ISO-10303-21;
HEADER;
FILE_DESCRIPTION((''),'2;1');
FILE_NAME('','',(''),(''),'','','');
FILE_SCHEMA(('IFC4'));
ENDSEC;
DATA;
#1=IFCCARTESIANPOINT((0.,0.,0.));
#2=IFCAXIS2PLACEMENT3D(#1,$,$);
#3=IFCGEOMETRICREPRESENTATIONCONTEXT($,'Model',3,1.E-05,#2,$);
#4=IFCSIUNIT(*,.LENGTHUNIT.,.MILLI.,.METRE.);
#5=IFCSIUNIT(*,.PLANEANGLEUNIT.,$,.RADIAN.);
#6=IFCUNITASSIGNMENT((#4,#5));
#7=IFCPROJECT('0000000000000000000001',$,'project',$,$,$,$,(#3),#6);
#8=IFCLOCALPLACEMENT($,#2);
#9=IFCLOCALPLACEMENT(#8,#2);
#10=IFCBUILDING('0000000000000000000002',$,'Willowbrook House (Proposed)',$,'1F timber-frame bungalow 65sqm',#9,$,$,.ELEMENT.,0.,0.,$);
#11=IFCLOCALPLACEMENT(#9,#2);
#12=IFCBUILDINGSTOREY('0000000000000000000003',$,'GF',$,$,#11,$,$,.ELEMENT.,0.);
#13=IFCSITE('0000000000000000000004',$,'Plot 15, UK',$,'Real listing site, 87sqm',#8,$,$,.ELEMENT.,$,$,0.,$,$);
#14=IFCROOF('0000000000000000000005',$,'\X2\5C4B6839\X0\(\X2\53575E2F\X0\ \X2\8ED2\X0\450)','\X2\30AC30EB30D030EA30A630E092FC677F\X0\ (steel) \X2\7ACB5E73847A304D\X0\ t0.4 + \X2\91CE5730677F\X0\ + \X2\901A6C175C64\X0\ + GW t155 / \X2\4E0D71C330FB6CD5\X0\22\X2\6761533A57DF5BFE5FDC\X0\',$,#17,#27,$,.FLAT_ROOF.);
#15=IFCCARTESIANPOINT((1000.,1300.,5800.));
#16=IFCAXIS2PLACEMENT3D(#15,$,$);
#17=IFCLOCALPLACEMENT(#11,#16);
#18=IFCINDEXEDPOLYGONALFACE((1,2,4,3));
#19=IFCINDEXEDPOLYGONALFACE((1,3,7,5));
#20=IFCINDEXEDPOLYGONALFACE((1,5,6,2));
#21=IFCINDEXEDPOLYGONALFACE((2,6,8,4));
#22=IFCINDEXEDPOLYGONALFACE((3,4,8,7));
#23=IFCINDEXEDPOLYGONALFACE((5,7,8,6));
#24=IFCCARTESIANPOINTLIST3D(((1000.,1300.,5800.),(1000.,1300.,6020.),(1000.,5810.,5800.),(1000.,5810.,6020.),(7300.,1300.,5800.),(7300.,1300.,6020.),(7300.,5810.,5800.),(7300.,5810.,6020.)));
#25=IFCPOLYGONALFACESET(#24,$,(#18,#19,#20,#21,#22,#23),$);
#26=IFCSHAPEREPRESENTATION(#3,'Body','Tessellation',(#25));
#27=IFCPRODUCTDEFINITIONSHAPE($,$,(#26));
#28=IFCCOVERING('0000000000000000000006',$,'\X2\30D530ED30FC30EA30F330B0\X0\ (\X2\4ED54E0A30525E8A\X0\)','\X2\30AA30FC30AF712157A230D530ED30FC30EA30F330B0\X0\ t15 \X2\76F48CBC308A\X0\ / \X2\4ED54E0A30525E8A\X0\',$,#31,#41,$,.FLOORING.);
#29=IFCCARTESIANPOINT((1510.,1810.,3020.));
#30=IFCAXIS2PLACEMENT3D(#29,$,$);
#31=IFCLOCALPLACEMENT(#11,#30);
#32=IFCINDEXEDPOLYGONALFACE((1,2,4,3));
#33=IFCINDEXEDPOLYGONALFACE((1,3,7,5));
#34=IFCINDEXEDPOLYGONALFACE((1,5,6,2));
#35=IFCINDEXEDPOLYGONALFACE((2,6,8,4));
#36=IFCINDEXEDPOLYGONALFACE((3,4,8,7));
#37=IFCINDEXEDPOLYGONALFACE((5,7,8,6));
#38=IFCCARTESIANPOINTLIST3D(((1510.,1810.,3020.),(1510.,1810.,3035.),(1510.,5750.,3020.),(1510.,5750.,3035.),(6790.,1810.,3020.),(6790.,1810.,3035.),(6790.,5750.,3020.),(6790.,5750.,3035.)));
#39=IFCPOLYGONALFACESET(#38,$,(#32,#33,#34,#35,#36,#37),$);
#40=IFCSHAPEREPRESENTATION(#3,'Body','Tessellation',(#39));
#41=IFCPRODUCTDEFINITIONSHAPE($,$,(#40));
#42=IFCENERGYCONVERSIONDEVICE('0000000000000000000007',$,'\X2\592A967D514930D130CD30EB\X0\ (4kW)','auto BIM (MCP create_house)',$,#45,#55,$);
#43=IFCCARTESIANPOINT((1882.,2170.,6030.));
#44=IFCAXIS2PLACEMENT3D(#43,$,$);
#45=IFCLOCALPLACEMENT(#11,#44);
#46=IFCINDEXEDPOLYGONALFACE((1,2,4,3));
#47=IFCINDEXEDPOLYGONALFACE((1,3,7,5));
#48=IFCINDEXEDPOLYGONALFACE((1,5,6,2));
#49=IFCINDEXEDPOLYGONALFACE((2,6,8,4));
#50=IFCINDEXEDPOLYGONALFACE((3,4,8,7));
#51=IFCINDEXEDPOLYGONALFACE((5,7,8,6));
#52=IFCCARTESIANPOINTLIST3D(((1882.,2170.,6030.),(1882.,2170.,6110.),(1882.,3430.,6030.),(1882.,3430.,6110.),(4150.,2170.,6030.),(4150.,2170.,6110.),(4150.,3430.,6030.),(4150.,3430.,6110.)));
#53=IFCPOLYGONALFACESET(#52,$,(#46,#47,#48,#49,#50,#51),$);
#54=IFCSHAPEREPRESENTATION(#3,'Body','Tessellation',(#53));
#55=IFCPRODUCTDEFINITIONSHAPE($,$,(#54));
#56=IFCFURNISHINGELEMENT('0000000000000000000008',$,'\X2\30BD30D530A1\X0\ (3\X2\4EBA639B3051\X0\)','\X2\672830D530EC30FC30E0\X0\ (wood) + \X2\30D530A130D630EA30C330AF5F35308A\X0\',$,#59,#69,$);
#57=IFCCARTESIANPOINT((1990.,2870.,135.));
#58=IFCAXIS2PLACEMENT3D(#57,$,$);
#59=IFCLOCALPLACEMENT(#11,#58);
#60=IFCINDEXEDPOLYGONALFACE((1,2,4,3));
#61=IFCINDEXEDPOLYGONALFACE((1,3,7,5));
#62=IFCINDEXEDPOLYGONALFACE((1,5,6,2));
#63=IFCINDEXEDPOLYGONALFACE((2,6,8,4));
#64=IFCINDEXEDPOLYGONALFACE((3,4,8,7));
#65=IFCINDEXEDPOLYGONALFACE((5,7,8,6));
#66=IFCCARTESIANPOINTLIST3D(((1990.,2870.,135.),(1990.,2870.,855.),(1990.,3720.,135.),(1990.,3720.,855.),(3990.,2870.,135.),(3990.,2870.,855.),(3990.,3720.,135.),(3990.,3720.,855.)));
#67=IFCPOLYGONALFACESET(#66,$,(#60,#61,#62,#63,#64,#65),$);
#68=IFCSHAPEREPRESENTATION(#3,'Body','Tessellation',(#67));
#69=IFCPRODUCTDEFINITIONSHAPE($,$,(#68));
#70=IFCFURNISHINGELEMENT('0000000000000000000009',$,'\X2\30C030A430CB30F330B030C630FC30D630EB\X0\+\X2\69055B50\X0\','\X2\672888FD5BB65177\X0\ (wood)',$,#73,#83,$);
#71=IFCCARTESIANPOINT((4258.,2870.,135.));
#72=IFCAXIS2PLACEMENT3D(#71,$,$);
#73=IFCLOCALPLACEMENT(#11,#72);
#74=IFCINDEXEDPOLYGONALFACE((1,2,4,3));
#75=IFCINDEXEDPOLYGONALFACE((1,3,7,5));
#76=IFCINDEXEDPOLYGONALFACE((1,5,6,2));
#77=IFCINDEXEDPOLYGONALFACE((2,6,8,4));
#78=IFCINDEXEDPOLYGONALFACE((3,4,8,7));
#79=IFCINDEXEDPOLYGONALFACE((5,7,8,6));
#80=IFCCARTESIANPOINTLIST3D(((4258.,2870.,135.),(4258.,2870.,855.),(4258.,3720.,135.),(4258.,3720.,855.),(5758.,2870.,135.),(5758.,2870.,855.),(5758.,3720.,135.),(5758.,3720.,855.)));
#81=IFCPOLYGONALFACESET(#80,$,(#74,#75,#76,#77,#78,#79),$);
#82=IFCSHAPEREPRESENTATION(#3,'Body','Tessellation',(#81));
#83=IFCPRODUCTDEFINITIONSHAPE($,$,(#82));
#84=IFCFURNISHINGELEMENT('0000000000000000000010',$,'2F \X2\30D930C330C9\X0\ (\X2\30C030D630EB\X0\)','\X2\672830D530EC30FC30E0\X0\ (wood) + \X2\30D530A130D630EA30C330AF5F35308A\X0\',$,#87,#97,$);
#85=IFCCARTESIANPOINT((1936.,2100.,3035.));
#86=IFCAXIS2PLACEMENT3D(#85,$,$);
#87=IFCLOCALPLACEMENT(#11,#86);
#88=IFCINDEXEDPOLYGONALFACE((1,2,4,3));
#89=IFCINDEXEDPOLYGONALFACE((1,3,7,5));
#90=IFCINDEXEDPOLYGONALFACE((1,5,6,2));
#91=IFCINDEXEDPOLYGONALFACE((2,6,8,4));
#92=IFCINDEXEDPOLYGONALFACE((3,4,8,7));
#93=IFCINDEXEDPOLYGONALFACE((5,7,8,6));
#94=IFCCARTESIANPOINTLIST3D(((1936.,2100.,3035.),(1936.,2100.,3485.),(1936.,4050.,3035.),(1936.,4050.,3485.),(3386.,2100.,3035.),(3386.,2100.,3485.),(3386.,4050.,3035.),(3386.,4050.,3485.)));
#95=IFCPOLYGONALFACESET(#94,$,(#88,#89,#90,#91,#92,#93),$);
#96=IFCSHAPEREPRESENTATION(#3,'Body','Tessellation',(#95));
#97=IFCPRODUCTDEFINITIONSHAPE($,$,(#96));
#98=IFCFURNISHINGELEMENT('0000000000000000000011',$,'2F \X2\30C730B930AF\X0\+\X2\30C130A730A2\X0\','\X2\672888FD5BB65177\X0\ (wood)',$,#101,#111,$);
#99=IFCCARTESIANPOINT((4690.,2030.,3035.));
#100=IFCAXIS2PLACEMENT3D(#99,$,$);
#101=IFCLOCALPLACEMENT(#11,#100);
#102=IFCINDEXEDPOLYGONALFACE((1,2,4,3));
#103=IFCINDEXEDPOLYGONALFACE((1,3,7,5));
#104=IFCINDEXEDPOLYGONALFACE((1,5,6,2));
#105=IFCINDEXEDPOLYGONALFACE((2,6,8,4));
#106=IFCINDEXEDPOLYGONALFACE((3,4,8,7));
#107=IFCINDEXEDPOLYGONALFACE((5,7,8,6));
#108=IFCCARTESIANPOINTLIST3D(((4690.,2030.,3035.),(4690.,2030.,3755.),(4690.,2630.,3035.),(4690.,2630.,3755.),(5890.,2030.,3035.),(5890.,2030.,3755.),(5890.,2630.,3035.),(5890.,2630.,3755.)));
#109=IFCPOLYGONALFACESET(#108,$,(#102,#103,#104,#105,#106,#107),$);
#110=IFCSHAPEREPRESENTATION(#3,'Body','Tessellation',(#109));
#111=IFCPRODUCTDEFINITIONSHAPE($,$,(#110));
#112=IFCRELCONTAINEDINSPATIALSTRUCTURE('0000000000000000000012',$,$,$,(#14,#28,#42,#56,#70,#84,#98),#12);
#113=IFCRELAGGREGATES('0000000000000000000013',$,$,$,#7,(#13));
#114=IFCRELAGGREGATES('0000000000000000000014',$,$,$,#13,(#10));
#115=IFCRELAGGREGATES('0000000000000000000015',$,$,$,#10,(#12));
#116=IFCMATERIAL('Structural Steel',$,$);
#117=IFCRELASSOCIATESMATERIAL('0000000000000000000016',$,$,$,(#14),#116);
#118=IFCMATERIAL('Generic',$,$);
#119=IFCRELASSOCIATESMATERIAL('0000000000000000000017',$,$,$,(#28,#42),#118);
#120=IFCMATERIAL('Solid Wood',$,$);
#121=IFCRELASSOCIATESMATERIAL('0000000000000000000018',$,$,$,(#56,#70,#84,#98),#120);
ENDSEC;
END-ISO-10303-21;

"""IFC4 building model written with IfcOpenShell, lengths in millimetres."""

from ifc_helpers import new_model, si_unit, frame, frame_2d, origin, place, context, project, spatial, rectangle, extrude, material, element, save


model = new_model("IFC4")

# Units and contexts
model_context = context("Model", 3, precision=1e-05, world=origin())
ifc_project = project(units=[si_unit("LENGTHUNIT", "METRE", prefix="MILLI"), si_unit("PLANEANGLEUNIT", "RADIAN")], contexts=[model_context])

# Site, building, storey
site_placement = place(None, origin())
site = spatial("IfcSite", under=ifc_project, at=site_placement, Name="Plot 15, UK", ObjectType="Real listing site, 87sqm", CompositionType="ELEMENT", RefElevation=0.0)
building_placement = place(site_placement, origin())
building = spatial("IfcBuilding", under=site, at=building_placement, Name="Willowbrook House (Proposed)", ObjectType="1F timber-frame bungalow 65sqm", CompositionType="ELEMENT", ElevationOfRefHeight=0.0, ElevationOfTerrain=0.0)
storey_placement = place(building_placement, origin())
storey = spatial("IfcBuildingStorey", under=building, at=storey_placement, Name="GF", CompositionType="ELEMENT", Elevation=0.0)

# Shared definitions
ifc_material_1 = material(Name="Solid Wood")

# Shared definitions
ifc_material_2 = material(Name="Generic")

# Roof
ifc_material_3 = material(Name="Structural Steel")
for number, where, name in (
    (1, (1000.0, 1300.0, 5800.0), "屋根(南帯 軒450)"),
):
    element("IfcRoof", number, at=place(storey_placement, frame(where)), inside=storey, material=ifc_material_3, Name=name, Description="ガルバリウム鋼板 (steel) 立平葺き t0.4 + 野地板 + 通気層 + GW t155 / 不燃・法22条区域対応", PredefinedType="FLAT_ROOF", context=model_context, shape_type="SweptSolid", body=[
        extrude(rectangle(XDim=6300.0, YDim=4510.0, at=frame_2d((3150.0, 2255.0))), frame((1000.0, 1300.0, 5800.0)), (0.0, 0.0, 1.0), 220.0),
    ])

# Covering
covering_placement = place(storey_placement, frame((1510.0, 1810.0, 3020.0)))
element("IfcCovering", 2, at=covering_placement, inside=storey, material=ifc_material_2, Name="フローリング (仕上げ床)", Description="オーク無垢フローリング t15 直貼り / 仕上げ床", PredefinedType="FLOORING", context=model_context, shape_type="SweptSolid", body=[
    extrude(rectangle(XDim=5280.0, YDim=3940.0, at=frame_2d((2640.0, 1970.0))), frame((1510.0, 1810.0, 3020.0)), (0.0, 0.0, 1.0), 15.0),
])

# Energy conversion device
energy_conversion_device_placement = place(storey_placement, frame((1882.0, 2170.0, 6030.0)))
element("IfcEnergyConversionDevice", 3, at=energy_conversion_device_placement, inside=storey, material=ifc_material_2, Name="太陽光パネル (4kW)", Description="auto BIM (MCP create_house)", context=model_context, shape_type="SweptSolid", body=[
    extrude(rectangle(XDim=2268.0, YDim=1260.0, at=frame_2d((1134.0, 630.0))), frame((1882.0, 2170.0, 6030.0)), (0.0, 0.0, 1.0), 80.0),
])

# Furnishing elements
furnishing_1_placement = place(storey_placement, frame((1990.0, 2870.0, 135.0)))
element("IfcFurnishingElement", 4, at=furnishing_1_placement, inside=storey, material=ifc_material_1, Name="ソファ (3人掛け)", Description="木フレーム (wood) + ファブリック張り", context=model_context, shape_type="SweptSolid", body=[
    extrude(rectangle(XDim=2000.0, YDim=850.0, at=frame_2d((1000.0, 425.0))), frame((1990.0, 2870.0, 135.0)), (0.0, 0.0, 1.0), 720.0),
])
furnishing_2_placement = place(storey_placement, frame((4258.0, 2870.0, 135.0)))
element("IfcFurnishingElement", 5, at=furnishing_2_placement, inside=storey, material=ifc_material_1, Name="ダイニングテーブル+椅子", Description="木製家具 (wood)", context=model_context, shape_type="SweptSolid", body=[
    extrude(rectangle(XDim=1500.0, YDim=850.0, at=frame_2d((750.0, 425.0))), frame((4258.0, 2870.0, 135.0)), (0.0, 0.0, 1.0), 720.0),
])
furnishing_3_placement = place(storey_placement, frame((1936.0, 2100.0, 3035.0)))
element("IfcFurnishingElement", 6, at=furnishing_3_placement, inside=storey, material=ifc_material_1, Name="2F ベッド (ダブル)", Description="木フレーム (wood) + ファブリック張り", context=model_context, shape_type="SweptSolid", body=[
    extrude(rectangle(XDim=1450.0, YDim=1950.0, at=frame_2d((725.0, 975.0))), frame((1936.0, 2100.0, 3035.0)), (0.0, 0.0, 1.0), 450.0),
])
furnishing_4_placement = place(storey_placement, frame((4690.0, 2030.0, 3035.0)))
element("IfcFurnishingElement", 7, at=furnishing_4_placement, inside=storey, material=ifc_material_1, Name="2F デスク+チェア", Description="木製家具 (wood)", context=model_context, shape_type="SweptSolid", body=[
    extrude(rectangle(XDim=1200.0, YDim=600.0, at=frame_2d((600.0, 300.0))), frame((4690.0, 2030.0, 3035.0)), (0.0, 0.0, 1.0), 720.0),
])

save(model, "model.ifc")
